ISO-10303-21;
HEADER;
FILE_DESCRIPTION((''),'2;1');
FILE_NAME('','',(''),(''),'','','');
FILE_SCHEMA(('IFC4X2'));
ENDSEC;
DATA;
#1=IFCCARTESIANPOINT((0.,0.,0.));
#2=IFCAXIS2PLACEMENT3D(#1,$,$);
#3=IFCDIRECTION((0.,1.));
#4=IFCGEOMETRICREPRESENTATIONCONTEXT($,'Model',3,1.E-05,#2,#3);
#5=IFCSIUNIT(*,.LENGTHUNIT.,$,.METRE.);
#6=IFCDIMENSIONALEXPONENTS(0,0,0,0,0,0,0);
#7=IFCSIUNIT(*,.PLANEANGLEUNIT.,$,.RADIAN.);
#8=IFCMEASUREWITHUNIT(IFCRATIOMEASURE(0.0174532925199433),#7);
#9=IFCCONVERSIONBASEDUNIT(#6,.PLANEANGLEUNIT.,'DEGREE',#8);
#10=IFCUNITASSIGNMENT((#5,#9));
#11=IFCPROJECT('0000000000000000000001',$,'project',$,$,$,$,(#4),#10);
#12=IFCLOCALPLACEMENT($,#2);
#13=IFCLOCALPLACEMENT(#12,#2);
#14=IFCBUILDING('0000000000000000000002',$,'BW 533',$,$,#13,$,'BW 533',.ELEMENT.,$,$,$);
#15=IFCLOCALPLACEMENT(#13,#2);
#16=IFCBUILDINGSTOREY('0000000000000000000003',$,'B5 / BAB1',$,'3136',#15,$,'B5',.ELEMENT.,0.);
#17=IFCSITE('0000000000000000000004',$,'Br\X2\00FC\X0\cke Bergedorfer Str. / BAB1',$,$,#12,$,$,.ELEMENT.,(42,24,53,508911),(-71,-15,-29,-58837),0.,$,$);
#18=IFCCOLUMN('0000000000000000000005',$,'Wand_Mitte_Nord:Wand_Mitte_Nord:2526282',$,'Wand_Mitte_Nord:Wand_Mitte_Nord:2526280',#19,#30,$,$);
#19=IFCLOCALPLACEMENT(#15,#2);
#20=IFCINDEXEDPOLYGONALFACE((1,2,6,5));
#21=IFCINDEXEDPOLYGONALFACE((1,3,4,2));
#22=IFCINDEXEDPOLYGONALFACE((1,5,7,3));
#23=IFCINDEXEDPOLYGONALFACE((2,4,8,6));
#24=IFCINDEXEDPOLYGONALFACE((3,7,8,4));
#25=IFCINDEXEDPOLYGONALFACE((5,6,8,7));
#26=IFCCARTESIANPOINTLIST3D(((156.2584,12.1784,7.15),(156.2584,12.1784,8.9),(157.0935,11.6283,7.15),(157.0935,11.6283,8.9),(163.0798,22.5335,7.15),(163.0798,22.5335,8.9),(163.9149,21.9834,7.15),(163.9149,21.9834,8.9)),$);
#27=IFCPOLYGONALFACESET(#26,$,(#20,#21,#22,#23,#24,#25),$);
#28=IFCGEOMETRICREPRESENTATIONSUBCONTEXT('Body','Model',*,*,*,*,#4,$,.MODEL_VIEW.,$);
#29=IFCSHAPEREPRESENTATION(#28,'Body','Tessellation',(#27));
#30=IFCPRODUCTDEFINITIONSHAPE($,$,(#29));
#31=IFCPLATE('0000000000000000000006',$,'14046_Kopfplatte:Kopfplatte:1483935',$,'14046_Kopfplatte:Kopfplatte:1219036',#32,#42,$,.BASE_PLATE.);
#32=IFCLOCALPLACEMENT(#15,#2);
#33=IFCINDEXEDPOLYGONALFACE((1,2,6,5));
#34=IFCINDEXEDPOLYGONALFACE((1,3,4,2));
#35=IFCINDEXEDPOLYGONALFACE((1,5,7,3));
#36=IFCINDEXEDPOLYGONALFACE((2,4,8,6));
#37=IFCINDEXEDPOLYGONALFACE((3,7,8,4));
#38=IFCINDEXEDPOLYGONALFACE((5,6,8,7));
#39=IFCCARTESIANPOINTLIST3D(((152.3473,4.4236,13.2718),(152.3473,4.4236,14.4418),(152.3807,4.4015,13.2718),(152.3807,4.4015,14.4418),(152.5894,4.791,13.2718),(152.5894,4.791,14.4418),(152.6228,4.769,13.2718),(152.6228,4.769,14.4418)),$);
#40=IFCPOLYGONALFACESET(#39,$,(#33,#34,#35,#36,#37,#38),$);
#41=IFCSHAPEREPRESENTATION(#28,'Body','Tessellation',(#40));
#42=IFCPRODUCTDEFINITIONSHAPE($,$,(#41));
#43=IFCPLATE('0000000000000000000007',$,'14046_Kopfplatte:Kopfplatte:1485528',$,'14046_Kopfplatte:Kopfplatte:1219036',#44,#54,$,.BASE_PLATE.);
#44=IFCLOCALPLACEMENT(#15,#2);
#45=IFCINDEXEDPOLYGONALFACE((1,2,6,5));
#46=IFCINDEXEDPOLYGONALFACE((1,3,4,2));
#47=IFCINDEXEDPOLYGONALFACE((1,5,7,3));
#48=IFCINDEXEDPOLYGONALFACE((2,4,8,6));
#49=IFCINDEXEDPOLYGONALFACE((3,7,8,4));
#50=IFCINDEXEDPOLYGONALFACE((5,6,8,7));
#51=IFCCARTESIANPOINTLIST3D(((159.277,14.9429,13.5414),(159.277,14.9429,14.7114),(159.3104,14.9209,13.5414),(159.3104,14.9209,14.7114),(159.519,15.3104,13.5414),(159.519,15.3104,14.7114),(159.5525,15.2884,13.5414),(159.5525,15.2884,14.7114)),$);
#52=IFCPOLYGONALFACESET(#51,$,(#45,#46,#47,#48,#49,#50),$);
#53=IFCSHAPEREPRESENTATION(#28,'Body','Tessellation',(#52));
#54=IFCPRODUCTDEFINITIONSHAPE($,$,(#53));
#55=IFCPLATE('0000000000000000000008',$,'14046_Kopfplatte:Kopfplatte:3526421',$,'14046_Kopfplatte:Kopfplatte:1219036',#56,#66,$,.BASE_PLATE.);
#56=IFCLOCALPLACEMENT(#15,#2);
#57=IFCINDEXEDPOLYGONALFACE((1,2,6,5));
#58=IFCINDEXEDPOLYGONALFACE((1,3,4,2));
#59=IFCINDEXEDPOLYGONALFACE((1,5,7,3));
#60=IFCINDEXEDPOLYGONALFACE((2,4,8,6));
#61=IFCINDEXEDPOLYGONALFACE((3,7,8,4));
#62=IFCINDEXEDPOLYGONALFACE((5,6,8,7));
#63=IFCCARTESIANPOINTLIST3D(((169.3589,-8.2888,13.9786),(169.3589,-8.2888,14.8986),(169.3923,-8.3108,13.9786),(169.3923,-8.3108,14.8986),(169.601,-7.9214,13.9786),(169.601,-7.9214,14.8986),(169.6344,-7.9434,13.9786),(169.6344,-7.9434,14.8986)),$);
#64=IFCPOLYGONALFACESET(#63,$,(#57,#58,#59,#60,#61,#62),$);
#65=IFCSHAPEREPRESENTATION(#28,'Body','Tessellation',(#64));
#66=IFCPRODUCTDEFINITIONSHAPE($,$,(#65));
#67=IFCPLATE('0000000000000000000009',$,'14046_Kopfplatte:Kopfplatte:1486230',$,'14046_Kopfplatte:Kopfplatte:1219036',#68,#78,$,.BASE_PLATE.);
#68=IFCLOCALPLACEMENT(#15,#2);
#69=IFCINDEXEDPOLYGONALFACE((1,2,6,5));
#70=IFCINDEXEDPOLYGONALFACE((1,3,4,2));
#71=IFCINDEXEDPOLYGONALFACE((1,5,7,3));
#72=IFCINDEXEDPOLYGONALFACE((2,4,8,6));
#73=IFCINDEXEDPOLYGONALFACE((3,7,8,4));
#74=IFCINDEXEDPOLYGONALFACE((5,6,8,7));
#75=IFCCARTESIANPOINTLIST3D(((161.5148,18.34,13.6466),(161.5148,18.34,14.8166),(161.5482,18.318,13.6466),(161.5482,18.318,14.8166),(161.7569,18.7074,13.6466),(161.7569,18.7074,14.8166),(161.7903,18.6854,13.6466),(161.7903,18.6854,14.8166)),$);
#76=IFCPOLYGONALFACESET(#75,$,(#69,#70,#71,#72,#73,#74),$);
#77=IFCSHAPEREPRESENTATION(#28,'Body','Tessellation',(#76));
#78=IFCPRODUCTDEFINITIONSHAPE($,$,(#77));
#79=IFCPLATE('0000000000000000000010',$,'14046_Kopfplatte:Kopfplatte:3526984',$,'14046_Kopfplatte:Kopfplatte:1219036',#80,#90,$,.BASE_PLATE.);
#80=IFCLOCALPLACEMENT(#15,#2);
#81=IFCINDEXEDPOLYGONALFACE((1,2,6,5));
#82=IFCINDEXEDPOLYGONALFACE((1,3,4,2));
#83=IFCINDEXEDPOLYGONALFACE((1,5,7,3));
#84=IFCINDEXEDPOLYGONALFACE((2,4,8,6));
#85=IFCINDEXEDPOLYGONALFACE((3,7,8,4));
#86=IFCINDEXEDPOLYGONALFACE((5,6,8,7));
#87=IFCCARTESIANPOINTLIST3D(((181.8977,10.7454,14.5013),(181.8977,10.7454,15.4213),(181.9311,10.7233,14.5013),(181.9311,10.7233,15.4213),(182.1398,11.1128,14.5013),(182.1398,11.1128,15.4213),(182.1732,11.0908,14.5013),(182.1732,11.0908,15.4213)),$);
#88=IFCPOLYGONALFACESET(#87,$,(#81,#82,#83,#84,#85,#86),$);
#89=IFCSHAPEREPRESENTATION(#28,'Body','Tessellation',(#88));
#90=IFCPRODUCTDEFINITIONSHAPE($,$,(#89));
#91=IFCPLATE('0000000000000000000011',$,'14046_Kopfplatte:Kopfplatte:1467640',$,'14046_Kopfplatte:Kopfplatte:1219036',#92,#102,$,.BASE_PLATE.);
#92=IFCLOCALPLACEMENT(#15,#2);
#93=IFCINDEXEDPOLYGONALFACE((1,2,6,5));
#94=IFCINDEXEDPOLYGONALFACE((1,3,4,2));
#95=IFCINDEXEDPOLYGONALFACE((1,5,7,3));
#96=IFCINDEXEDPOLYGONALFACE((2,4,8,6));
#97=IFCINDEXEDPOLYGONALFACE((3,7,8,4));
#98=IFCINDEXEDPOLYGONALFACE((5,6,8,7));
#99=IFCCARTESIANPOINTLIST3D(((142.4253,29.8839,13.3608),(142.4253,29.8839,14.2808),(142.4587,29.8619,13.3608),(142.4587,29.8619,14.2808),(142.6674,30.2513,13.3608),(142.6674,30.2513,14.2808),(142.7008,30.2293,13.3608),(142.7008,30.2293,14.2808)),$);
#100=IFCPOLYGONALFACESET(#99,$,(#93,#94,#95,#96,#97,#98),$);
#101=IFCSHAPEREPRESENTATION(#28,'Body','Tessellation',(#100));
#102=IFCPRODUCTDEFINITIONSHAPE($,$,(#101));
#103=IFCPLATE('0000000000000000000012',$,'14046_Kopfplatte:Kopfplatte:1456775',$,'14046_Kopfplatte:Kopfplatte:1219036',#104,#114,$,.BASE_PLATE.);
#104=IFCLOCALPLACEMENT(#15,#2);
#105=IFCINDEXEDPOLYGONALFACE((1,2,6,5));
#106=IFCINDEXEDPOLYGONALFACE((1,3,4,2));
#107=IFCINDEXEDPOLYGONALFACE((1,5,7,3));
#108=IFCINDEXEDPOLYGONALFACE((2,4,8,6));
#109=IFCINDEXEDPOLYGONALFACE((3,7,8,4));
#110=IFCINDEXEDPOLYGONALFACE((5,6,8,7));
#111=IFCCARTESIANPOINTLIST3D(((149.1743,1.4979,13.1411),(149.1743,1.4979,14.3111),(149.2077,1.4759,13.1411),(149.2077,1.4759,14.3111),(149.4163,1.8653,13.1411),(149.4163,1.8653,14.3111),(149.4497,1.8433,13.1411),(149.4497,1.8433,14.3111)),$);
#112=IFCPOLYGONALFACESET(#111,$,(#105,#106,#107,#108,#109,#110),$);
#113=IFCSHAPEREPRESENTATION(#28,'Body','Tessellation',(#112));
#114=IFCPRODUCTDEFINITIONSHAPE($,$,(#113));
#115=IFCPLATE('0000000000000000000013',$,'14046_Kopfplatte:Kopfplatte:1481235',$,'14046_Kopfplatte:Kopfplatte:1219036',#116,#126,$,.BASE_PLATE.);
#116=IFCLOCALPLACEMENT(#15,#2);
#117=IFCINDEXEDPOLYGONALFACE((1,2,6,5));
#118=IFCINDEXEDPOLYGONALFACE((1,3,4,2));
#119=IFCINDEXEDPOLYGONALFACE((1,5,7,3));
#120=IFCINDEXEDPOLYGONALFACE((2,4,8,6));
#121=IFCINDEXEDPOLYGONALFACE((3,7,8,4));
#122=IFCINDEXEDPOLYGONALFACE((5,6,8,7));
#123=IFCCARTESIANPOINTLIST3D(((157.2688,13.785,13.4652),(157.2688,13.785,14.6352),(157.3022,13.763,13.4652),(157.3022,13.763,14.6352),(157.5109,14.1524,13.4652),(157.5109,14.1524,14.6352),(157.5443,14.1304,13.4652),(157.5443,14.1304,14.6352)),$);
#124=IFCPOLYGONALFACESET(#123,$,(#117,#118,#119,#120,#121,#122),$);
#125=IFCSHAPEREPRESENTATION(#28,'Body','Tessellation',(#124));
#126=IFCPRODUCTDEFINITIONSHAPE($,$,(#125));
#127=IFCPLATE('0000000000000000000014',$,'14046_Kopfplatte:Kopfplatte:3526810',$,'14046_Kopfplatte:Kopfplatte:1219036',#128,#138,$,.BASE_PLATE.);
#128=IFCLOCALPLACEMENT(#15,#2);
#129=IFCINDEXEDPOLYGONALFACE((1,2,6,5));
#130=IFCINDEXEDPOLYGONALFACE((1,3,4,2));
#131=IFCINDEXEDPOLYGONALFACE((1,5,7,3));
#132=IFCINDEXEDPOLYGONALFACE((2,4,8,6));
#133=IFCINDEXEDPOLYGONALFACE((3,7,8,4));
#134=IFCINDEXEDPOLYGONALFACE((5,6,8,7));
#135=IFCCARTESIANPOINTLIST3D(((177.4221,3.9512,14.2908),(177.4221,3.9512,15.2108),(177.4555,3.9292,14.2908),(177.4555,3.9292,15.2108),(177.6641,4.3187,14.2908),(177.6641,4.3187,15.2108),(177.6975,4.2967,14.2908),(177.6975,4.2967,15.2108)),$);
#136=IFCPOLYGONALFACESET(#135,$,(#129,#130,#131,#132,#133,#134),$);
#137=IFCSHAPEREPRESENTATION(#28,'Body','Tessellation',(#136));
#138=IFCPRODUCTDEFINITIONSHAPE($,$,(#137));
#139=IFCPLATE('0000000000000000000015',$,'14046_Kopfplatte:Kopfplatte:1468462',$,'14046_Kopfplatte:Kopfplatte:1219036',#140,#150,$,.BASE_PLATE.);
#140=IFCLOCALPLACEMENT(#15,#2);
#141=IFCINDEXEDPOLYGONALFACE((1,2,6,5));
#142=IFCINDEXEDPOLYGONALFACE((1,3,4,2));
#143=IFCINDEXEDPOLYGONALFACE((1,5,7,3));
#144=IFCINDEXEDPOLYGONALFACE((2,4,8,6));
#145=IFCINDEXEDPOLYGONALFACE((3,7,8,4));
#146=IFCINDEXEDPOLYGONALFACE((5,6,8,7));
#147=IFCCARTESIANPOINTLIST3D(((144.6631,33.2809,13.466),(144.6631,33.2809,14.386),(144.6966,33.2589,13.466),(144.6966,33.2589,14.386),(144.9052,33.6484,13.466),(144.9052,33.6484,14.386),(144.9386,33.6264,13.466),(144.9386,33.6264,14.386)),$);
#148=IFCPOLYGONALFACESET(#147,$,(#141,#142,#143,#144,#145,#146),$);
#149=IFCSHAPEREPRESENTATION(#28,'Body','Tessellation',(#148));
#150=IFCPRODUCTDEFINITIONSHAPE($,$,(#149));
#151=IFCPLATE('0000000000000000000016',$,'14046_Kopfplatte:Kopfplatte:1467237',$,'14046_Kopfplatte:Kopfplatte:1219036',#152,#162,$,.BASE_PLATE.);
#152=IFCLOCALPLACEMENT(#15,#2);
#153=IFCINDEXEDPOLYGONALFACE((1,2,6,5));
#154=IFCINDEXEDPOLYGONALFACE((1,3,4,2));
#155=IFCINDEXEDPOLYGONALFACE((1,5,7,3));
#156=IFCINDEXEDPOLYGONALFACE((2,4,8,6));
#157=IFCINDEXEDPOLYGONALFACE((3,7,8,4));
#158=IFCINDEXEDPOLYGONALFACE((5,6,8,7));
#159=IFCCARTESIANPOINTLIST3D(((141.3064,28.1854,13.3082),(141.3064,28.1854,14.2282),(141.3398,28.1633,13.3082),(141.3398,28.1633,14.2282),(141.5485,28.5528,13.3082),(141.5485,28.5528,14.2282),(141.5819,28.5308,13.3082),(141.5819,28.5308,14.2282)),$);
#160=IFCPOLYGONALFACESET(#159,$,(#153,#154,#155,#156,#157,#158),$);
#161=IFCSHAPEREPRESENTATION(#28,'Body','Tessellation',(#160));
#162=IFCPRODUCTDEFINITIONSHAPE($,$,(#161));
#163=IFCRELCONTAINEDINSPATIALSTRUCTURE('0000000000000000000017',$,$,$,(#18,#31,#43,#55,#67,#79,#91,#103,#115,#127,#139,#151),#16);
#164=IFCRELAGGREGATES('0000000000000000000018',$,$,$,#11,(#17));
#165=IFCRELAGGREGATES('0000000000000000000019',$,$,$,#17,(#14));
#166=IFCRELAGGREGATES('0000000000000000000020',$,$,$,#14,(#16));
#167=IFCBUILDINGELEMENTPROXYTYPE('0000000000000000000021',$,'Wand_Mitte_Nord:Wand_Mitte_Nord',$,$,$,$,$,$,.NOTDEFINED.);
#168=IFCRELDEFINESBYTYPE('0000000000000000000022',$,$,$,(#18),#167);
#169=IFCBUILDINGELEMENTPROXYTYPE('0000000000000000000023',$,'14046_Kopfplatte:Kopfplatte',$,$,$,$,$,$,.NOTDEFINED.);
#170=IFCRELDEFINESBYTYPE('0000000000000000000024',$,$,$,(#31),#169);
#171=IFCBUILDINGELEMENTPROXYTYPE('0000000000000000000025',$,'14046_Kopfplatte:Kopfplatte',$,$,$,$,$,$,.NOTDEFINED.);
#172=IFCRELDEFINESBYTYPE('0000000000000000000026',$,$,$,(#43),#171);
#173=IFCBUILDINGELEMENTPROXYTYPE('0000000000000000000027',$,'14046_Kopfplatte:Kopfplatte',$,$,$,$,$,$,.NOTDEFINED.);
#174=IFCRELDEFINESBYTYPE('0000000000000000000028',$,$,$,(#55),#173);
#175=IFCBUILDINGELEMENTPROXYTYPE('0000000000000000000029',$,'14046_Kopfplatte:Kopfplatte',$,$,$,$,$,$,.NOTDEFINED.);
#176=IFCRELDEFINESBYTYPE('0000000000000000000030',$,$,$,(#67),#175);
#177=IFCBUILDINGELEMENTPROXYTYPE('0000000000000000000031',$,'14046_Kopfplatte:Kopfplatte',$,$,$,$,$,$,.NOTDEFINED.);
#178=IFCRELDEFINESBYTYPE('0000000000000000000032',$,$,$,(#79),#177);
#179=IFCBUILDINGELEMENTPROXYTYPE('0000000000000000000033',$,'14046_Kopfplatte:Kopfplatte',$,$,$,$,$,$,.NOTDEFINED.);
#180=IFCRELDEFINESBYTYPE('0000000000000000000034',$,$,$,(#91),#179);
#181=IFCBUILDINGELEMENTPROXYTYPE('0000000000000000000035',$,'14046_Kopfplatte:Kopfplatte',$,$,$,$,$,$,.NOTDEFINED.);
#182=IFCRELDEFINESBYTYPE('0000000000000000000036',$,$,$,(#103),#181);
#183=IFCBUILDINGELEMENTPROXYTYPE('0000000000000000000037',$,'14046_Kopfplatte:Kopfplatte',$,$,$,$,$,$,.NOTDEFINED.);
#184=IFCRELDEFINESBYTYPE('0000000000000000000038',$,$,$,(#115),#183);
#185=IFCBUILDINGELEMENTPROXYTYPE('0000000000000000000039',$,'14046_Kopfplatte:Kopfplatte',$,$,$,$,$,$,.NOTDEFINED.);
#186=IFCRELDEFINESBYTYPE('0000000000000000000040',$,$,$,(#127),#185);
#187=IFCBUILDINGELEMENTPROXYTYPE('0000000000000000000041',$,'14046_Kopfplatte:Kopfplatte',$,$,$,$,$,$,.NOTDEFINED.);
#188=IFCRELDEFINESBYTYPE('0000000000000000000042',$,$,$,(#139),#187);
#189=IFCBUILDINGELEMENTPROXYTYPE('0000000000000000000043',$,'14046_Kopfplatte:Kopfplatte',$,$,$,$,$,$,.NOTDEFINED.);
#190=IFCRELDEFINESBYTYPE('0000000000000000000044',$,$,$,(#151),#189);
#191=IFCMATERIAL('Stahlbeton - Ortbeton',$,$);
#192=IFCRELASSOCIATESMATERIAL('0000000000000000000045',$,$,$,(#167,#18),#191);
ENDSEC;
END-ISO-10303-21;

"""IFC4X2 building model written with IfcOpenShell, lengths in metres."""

from ifc_helpers import new_model, entity, si_unit, converted_unit, direction, frame, frame_2d, origin, origin_2d_with_axis, place, context, subcontext, project, spatial, rectangle, extrude, source, transform, mapped, material, type_object, type_shapes, element, save


model = new_model("IFC4X2")

# Units and contexts
model_context = context("Model", 3, precision=1e-05, world=origin(), true_north=direction((0.0, 1.0)))
body_context = subcontext(model_context, "Body", "Model", "MODEL_VIEW")
ifc_project = project(units=[si_unit("LENGTHUNIT", "METRE"), converted_unit("PLANEANGLEUNIT", "DEGREE", entity("IfcRatioMeasure", 0.0174532925199433), si_unit("PLANEANGLEUNIT", "RADIAN"), dimensions=[0, 0, 0, 0, 0, 0, 0])], contexts=[model_context])

# Site, building, storey
site_placement = place(None, origin())
site = spatial("IfcSite", under=ifc_project, at=site_placement, Name="Brücke Bergedorfer Str. / BAB1", CompositionType="ELEMENT", RefLatitude=(42, 24, 53, 508911), RefLongitude=(-71, -15, -29, -58837), RefElevation=0.0)
building_placement = place(site_placement, origin())
building = spatial("IfcBuilding", under=site, at=building_placement, Name="BW 533", LongName="BW 533", CompositionType="ELEMENT")
storey_placement = place(building_placement, origin())
storey = spatial("IfcBuildingStorey", under=building, at=storey_placement, Name="B5 / BAB1", ObjectType="3136", LongName="B5", CompositionType="ELEMENT", Elevation=0.0)

# Shared definitions
ifc_material_1 = material(Name="Stahlbeton - Ortbeton")

# Column
building_element_proxy_type_1 = type_object("IfcBuildingElementProxyType", Name="Wand_Mitte_Nord:Wand_Mitte_Nord", PredefinedType="NOTDEFINED", material=ifc_material_1)
shared_shape_1 = source(origin(), body_context, "Body", "SweptSolid", [
    extrude(rectangle(XDim=12.4, YDim=1.0, at=frame_2d((0.0, 0.0), x_axis=(1.0, 0.0))), frame((160.0866, 17.0809, 7.15), z_axis=(0.0, 0.0, 1.0), x_axis=(0.550116, 0.835088, 0.0)), (0.0, 0.0, 1.0), 1.75),
])
type_shapes(building_element_proxy_type_1, [shared_shape_1])
column_placement = place(storey_placement, origin())
element("IfcColumn", 1, at=column_placement, inside=storey, type_object=building_element_proxy_type_1, material=ifc_material_1, Name="Wand_Mitte_Nord:Wand_Mitte_Nord:2526282", ObjectType="Wand_Mitte_Nord:Wand_Mitte_Nord:2526280", context=body_context, shape_type="MappedRepresentation", body=[
    mapped(shared_shape_1, transform((0.0, 0.0, 0.0), scale=1.0)),
])

# Plates
building_element_proxy_type_2 = type_object("IfcBuildingElementProxyType", Name="14046_Kopfplatte:Kopfplatte", PredefinedType="NOTDEFINED")
shared_shape_2 = source(origin(), body_context, "Body", "SweptSolid", [
    extrude(rectangle(XDim=0.04, YDim=0.44, at=frame_2d((0.0, 0.0), x_axis=(1.0, 0.0))), frame((152.4851, 4.5963, 13.2718), z_axis=(0.0, 0.0, 1.0), x_axis=(-0.835088, 0.550116, 0.0)), (0.0, 0.0, 1.0), 1.17),
])
type_shapes(building_element_proxy_type_2, [shared_shape_2])
plate_1_placement = place(storey_placement, origin())
element("IfcPlate", 2, at=plate_1_placement, inside=storey, type_object=building_element_proxy_type_2, Name="14046_Kopfplatte:Kopfplatte:1483935", ObjectType="14046_Kopfplatte:Kopfplatte:1219036", PredefinedType="BASE_PLATE", context=body_context, shape_type="MappedRepresentation", body=[
    mapped(shared_shape_2, transform((0.0, 0.0, 0.0), scale=1.0)),
])
building_element_proxy_type_3 = type_object("IfcBuildingElementProxyType", Name="14046_Kopfplatte:Kopfplatte", PredefinedType="NOTDEFINED")
shared_shape_3 = source(origin(), body_context, "Body", "SweptSolid", [
    extrude(rectangle(XDim=0.04, YDim=0.44, at=frame_2d((0.0, 0.0), x_axis=(1.0, 0.0))), frame((159.4147, 15.1157, 13.5414), z_axis=(0.0, 0.0, 1.0), x_axis=(-0.835088, 0.550116, 0.0)), (0.0, 0.0, 1.0), 1.17),
])
type_shapes(building_element_proxy_type_3, [shared_shape_3])
plate_2_placement = place(storey_placement, origin())
element("IfcPlate", 3, at=plate_2_placement, inside=storey, type_object=building_element_proxy_type_3, Name="14046_Kopfplatte:Kopfplatte:1485528", ObjectType="14046_Kopfplatte:Kopfplatte:1219036", PredefinedType="BASE_PLATE", context=body_context, shape_type="MappedRepresentation", body=[
    mapped(shared_shape_3, transform((0.0, 0.0, 0.0), scale=1.0)),
])
building_element_proxy_type_4 = type_object("IfcBuildingElementProxyType", Name="14046_Kopfplatte:Kopfplatte", PredefinedType="NOTDEFINED")
shared_shape_4 = source(origin(), body_context, "Body", "SweptSolid", [
    extrude(rectangle(XDim=0.04, YDim=0.44, at=frame_2d((0.0, 0.0), x_axis=(1.0, 0.0))), frame((169.4966, -8.1161, 13.9786), z_axis=(0.0, 0.0, 1.0), x_axis=(0.835088, -0.550116, 0.0)), (0.0, 0.0, 1.0), 0.92),
])
type_shapes(building_element_proxy_type_4, [shared_shape_4])
plate_3_placement = place(storey_placement, origin())
element("IfcPlate", 4, at=plate_3_placement, inside=storey, type_object=building_element_proxy_type_4, Name="14046_Kopfplatte:Kopfplatte:3526421", ObjectType="14046_Kopfplatte:Kopfplatte:1219036", PredefinedType="BASE_PLATE", context=body_context, shape_type="MappedRepresentation", body=[
    mapped(shared_shape_4, transform((0.0, 0.0, 0.0), scale=1.0)),
])
building_element_proxy_type_5 = type_object("IfcBuildingElementProxyType", Name="14046_Kopfplatte:Kopfplatte", PredefinedType="NOTDEFINED")
shared_shape_5 = source(origin(), body_context, "Body", "SweptSolid", [
    extrude(rectangle(XDim=0.04, YDim=0.44, at=frame_2d((0.0, 0.0), x_axis=(1.0, 0.0))), frame((161.6525, 18.5127, 13.6466), z_axis=(0.0, 0.0, 1.0), x_axis=(-0.835088, 0.550116, 0.0)), (0.0, 0.0, 1.0), 1.17),
])
type_shapes(building_element_proxy_type_5, [shared_shape_5])
plate_4_placement = place(storey_placement, origin())
element("IfcPlate", 5, at=plate_4_placement, inside=storey, type_object=building_element_proxy_type_5, Name="14046_Kopfplatte:Kopfplatte:1486230", ObjectType="14046_Kopfplatte:Kopfplatte:1219036", PredefinedType="BASE_PLATE", context=body_context, shape_type="MappedRepresentation", body=[
    mapped(shared_shape_5, transform((0.0, 0.0, 0.0), scale=1.0)),
])
building_element_proxy_type_6 = type_object("IfcBuildingElementProxyType", Name="14046_Kopfplatte:Kopfplatte", PredefinedType="NOTDEFINED")
shared_shape_6 = source(origin(), body_context, "Body", "SweptSolid", [
    extrude(rectangle(XDim=0.04, YDim=0.44, at=frame_2d((0.0, 0.0), x_axis=(1.0, 0.0))), frame((182.0354, 10.9181, 14.5013), z_axis=(0.0, 0.0, 1.0), x_axis=(0.835088, -0.550116, 0.0)), (0.0, 0.0, 1.0), 0.92),
])
type_shapes(building_element_proxy_type_6, [shared_shape_6])
plate_5_placement = place(storey_placement, origin())
element("IfcPlate", 6, at=plate_5_placement, inside=storey, type_object=building_element_proxy_type_6, Name="14046_Kopfplatte:Kopfplatte:3526984", ObjectType="14046_Kopfplatte:Kopfplatte:1219036", PredefinedType="BASE_PLATE", context=body_context, shape_type="MappedRepresentation", body=[
    mapped(shared_shape_6, transform((0.0, 0.0, 0.0), scale=1.0)),
])
building_element_proxy_type_7 = type_object("IfcBuildingElementProxyType", Name="14046_Kopfplatte:Kopfplatte", PredefinedType="NOTDEFINED")
shared_shape_7 = source(origin(), body_context, "Body", "SweptSolid", [
    extrude(rectangle(XDim=0.04, YDim=0.44, at=frame_2d((0.0, 0.0), x_axis=(1.0, 0.0))), frame((142.5631, 30.0566, 13.3608), z_axis=(0.0, 0.0, 1.0), x_axis=(-0.835088, 0.550116, 0.0)), (0.0, 0.0, 1.0), 0.92),
])
type_shapes(building_element_proxy_type_7, [shared_shape_7])
plate_6_placement = place(storey_placement, origin())
element("IfcPlate", 7, at=plate_6_placement, inside=storey, type_object=building_element_proxy_type_7, Name="14046_Kopfplatte:Kopfplatte:1467640", ObjectType="14046_Kopfplatte:Kopfplatte:1219036", PredefinedType="BASE_PLATE", context=body_context, shape_type="MappedRepresentation", body=[
    mapped(shared_shape_7, transform((0.0, 0.0, 0.0), scale=1.0)),
])
building_element_proxy_type_8 = type_object("IfcBuildingElementProxyType", Name="14046_Kopfplatte:Kopfplatte", PredefinedType="NOTDEFINED")
shared_shape_8 = source(origin(), body_context, "Body", "SweptSolid", [
    extrude(rectangle(XDim=0.04, YDim=0.44, at=origin_2d_with_axis()), frame((149.312, 1.6706, 13.1411), z_axis=(0.0, 0.0, 1.0), x_axis=(0.835088, -0.550116, 0.0)), (0.0, 0.0, 1.0), 1.17),
])
type_shapes(building_element_proxy_type_8, [shared_shape_8])
plate_7_placement = place(storey_placement, origin())
element("IfcPlate", 8, at=plate_7_placement, inside=storey, type_object=building_element_proxy_type_8, Name="14046_Kopfplatte:Kopfplatte:1456775", ObjectType="14046_Kopfplatte:Kopfplatte:1219036", PredefinedType="BASE_PLATE", context=body_context, shape_type="MappedRepresentation", body=[
    mapped(shared_shape_8, transform((0.0, 0.0, 0.0), scale=1.0)),
])
building_element_proxy_type_9 = type_object("IfcBuildingElementProxyType", Name="14046_Kopfplatte:Kopfplatte", PredefinedType="NOTDEFINED")
shared_shape_9 = source(origin(), body_context, "Body", "SweptSolid", [
    extrude(rectangle(XDim=0.04, YDim=0.44, at=frame_2d((0.0, 0.0), x_axis=(1.0, 0.0))), frame((157.4065, 13.9577, 13.4652), z_axis=(0.0, 0.0, 1.0), x_axis=(0.835088, -0.550116, 0.0)), (0.0, 0.0, 1.0), 1.17),
])
type_shapes(building_element_proxy_type_9, [shared_shape_9])
plate_8_placement = place(storey_placement, origin())
element("IfcPlate", 9, at=plate_8_placement, inside=storey, type_object=building_element_proxy_type_9, Name="14046_Kopfplatte:Kopfplatte:1481235", ObjectType="14046_Kopfplatte:Kopfplatte:1219036", PredefinedType="BASE_PLATE", context=body_context, shape_type="MappedRepresentation", body=[
    mapped(shared_shape_9, transform((0.0, 0.0, 0.0), scale=1.0)),
])
building_element_proxy_type_10 = type_object("IfcBuildingElementProxyType", Name="14046_Kopfplatte:Kopfplatte", PredefinedType="NOTDEFINED")
shared_shape_10 = source(origin(), body_context, "Body", "SweptSolid", [
    extrude(rectangle(XDim=0.04, YDim=0.44, at=frame_2d((0.0, 0.0), x_axis=(1.0, 0.0))), frame((177.5598, 4.124, 14.2908), z_axis=(0.0, 0.0, 1.0), x_axis=(0.835088, -0.550116, 0.0)), (0.0, 0.0, 1.0), 0.92),
])
type_shapes(building_element_proxy_type_10, [shared_shape_10])
plate_9_placement = place(storey_placement, origin())
element("IfcPlate", 10, at=plate_9_placement, inside=storey, type_object=building_element_proxy_type_10, Name="14046_Kopfplatte:Kopfplatte:3526810", ObjectType="14046_Kopfplatte:Kopfplatte:1219036", PredefinedType="BASE_PLATE", context=body_context, shape_type="MappedRepresentation", body=[
    mapped(shared_shape_10, transform((0.0, 0.0, 0.0), scale=1.0)),
])
building_element_proxy_type_11 = type_object("IfcBuildingElementProxyType", Name="14046_Kopfplatte:Kopfplatte", PredefinedType="NOTDEFINED")
shared_shape_11 = source(origin(), body_context, "Body", "SweptSolid", [
    extrude(rectangle(XDim=0.04, YDim=0.44, at=frame_2d((0.0, 0.0), x_axis=(1.0, 0.0))), frame((144.8009, 33.4537, 13.466), z_axis=(0.0, 0.0, 1.0), x_axis=(-0.835088, 0.550116, 0.0)), (0.0, 0.0, 1.0), 0.92),
])
type_shapes(building_element_proxy_type_11, [shared_shape_11])
plate_10_placement = place(storey_placement, origin())
element("IfcPlate", 11, at=plate_10_placement, inside=storey, type_object=building_element_proxy_type_11, Name="14046_Kopfplatte:Kopfplatte:1468462", ObjectType="14046_Kopfplatte:Kopfplatte:1219036", PredefinedType="BASE_PLATE", context=body_context, shape_type="MappedRepresentation", body=[
    mapped(shared_shape_11, transform((0.0, 0.0, 0.0), scale=1.0)),
])
building_element_proxy_type_12 = type_object("IfcBuildingElementProxyType", Name="14046_Kopfplatte:Kopfplatte", PredefinedType="NOTDEFINED")
shared_shape_12 = source(origin(), body_context, "Body", "SweptSolid", [
    extrude(rectangle(XDim=0.04, YDim=0.44, at=frame_2d((0.0, 0.0), x_axis=(1.0, 0.0))), frame((141.4441, 28.3581, 13.3082), z_axis=(0.0, 0.0, 1.0), x_axis=(-0.835088, 0.550116, 0.0)), (0.0, 0.0, 1.0), 0.92),
])
type_shapes(building_element_proxy_type_12, [shared_shape_12])
plate_11_placement = place(storey_placement, origin())
element("IfcPlate", 12, at=plate_11_placement, inside=storey, type_object=building_element_proxy_type_12, Name="14046_Kopfplatte:Kopfplatte:1467237", ObjectType="14046_Kopfplatte:Kopfplatte:1219036", PredefinedType="BASE_PLATE", context=body_context, shape_type="MappedRepresentation", body=[
    mapped(shared_shape_12, transform((0.0, 0.0, 0.0), scale=1.0)),
])

save(model, "model.ifc")
